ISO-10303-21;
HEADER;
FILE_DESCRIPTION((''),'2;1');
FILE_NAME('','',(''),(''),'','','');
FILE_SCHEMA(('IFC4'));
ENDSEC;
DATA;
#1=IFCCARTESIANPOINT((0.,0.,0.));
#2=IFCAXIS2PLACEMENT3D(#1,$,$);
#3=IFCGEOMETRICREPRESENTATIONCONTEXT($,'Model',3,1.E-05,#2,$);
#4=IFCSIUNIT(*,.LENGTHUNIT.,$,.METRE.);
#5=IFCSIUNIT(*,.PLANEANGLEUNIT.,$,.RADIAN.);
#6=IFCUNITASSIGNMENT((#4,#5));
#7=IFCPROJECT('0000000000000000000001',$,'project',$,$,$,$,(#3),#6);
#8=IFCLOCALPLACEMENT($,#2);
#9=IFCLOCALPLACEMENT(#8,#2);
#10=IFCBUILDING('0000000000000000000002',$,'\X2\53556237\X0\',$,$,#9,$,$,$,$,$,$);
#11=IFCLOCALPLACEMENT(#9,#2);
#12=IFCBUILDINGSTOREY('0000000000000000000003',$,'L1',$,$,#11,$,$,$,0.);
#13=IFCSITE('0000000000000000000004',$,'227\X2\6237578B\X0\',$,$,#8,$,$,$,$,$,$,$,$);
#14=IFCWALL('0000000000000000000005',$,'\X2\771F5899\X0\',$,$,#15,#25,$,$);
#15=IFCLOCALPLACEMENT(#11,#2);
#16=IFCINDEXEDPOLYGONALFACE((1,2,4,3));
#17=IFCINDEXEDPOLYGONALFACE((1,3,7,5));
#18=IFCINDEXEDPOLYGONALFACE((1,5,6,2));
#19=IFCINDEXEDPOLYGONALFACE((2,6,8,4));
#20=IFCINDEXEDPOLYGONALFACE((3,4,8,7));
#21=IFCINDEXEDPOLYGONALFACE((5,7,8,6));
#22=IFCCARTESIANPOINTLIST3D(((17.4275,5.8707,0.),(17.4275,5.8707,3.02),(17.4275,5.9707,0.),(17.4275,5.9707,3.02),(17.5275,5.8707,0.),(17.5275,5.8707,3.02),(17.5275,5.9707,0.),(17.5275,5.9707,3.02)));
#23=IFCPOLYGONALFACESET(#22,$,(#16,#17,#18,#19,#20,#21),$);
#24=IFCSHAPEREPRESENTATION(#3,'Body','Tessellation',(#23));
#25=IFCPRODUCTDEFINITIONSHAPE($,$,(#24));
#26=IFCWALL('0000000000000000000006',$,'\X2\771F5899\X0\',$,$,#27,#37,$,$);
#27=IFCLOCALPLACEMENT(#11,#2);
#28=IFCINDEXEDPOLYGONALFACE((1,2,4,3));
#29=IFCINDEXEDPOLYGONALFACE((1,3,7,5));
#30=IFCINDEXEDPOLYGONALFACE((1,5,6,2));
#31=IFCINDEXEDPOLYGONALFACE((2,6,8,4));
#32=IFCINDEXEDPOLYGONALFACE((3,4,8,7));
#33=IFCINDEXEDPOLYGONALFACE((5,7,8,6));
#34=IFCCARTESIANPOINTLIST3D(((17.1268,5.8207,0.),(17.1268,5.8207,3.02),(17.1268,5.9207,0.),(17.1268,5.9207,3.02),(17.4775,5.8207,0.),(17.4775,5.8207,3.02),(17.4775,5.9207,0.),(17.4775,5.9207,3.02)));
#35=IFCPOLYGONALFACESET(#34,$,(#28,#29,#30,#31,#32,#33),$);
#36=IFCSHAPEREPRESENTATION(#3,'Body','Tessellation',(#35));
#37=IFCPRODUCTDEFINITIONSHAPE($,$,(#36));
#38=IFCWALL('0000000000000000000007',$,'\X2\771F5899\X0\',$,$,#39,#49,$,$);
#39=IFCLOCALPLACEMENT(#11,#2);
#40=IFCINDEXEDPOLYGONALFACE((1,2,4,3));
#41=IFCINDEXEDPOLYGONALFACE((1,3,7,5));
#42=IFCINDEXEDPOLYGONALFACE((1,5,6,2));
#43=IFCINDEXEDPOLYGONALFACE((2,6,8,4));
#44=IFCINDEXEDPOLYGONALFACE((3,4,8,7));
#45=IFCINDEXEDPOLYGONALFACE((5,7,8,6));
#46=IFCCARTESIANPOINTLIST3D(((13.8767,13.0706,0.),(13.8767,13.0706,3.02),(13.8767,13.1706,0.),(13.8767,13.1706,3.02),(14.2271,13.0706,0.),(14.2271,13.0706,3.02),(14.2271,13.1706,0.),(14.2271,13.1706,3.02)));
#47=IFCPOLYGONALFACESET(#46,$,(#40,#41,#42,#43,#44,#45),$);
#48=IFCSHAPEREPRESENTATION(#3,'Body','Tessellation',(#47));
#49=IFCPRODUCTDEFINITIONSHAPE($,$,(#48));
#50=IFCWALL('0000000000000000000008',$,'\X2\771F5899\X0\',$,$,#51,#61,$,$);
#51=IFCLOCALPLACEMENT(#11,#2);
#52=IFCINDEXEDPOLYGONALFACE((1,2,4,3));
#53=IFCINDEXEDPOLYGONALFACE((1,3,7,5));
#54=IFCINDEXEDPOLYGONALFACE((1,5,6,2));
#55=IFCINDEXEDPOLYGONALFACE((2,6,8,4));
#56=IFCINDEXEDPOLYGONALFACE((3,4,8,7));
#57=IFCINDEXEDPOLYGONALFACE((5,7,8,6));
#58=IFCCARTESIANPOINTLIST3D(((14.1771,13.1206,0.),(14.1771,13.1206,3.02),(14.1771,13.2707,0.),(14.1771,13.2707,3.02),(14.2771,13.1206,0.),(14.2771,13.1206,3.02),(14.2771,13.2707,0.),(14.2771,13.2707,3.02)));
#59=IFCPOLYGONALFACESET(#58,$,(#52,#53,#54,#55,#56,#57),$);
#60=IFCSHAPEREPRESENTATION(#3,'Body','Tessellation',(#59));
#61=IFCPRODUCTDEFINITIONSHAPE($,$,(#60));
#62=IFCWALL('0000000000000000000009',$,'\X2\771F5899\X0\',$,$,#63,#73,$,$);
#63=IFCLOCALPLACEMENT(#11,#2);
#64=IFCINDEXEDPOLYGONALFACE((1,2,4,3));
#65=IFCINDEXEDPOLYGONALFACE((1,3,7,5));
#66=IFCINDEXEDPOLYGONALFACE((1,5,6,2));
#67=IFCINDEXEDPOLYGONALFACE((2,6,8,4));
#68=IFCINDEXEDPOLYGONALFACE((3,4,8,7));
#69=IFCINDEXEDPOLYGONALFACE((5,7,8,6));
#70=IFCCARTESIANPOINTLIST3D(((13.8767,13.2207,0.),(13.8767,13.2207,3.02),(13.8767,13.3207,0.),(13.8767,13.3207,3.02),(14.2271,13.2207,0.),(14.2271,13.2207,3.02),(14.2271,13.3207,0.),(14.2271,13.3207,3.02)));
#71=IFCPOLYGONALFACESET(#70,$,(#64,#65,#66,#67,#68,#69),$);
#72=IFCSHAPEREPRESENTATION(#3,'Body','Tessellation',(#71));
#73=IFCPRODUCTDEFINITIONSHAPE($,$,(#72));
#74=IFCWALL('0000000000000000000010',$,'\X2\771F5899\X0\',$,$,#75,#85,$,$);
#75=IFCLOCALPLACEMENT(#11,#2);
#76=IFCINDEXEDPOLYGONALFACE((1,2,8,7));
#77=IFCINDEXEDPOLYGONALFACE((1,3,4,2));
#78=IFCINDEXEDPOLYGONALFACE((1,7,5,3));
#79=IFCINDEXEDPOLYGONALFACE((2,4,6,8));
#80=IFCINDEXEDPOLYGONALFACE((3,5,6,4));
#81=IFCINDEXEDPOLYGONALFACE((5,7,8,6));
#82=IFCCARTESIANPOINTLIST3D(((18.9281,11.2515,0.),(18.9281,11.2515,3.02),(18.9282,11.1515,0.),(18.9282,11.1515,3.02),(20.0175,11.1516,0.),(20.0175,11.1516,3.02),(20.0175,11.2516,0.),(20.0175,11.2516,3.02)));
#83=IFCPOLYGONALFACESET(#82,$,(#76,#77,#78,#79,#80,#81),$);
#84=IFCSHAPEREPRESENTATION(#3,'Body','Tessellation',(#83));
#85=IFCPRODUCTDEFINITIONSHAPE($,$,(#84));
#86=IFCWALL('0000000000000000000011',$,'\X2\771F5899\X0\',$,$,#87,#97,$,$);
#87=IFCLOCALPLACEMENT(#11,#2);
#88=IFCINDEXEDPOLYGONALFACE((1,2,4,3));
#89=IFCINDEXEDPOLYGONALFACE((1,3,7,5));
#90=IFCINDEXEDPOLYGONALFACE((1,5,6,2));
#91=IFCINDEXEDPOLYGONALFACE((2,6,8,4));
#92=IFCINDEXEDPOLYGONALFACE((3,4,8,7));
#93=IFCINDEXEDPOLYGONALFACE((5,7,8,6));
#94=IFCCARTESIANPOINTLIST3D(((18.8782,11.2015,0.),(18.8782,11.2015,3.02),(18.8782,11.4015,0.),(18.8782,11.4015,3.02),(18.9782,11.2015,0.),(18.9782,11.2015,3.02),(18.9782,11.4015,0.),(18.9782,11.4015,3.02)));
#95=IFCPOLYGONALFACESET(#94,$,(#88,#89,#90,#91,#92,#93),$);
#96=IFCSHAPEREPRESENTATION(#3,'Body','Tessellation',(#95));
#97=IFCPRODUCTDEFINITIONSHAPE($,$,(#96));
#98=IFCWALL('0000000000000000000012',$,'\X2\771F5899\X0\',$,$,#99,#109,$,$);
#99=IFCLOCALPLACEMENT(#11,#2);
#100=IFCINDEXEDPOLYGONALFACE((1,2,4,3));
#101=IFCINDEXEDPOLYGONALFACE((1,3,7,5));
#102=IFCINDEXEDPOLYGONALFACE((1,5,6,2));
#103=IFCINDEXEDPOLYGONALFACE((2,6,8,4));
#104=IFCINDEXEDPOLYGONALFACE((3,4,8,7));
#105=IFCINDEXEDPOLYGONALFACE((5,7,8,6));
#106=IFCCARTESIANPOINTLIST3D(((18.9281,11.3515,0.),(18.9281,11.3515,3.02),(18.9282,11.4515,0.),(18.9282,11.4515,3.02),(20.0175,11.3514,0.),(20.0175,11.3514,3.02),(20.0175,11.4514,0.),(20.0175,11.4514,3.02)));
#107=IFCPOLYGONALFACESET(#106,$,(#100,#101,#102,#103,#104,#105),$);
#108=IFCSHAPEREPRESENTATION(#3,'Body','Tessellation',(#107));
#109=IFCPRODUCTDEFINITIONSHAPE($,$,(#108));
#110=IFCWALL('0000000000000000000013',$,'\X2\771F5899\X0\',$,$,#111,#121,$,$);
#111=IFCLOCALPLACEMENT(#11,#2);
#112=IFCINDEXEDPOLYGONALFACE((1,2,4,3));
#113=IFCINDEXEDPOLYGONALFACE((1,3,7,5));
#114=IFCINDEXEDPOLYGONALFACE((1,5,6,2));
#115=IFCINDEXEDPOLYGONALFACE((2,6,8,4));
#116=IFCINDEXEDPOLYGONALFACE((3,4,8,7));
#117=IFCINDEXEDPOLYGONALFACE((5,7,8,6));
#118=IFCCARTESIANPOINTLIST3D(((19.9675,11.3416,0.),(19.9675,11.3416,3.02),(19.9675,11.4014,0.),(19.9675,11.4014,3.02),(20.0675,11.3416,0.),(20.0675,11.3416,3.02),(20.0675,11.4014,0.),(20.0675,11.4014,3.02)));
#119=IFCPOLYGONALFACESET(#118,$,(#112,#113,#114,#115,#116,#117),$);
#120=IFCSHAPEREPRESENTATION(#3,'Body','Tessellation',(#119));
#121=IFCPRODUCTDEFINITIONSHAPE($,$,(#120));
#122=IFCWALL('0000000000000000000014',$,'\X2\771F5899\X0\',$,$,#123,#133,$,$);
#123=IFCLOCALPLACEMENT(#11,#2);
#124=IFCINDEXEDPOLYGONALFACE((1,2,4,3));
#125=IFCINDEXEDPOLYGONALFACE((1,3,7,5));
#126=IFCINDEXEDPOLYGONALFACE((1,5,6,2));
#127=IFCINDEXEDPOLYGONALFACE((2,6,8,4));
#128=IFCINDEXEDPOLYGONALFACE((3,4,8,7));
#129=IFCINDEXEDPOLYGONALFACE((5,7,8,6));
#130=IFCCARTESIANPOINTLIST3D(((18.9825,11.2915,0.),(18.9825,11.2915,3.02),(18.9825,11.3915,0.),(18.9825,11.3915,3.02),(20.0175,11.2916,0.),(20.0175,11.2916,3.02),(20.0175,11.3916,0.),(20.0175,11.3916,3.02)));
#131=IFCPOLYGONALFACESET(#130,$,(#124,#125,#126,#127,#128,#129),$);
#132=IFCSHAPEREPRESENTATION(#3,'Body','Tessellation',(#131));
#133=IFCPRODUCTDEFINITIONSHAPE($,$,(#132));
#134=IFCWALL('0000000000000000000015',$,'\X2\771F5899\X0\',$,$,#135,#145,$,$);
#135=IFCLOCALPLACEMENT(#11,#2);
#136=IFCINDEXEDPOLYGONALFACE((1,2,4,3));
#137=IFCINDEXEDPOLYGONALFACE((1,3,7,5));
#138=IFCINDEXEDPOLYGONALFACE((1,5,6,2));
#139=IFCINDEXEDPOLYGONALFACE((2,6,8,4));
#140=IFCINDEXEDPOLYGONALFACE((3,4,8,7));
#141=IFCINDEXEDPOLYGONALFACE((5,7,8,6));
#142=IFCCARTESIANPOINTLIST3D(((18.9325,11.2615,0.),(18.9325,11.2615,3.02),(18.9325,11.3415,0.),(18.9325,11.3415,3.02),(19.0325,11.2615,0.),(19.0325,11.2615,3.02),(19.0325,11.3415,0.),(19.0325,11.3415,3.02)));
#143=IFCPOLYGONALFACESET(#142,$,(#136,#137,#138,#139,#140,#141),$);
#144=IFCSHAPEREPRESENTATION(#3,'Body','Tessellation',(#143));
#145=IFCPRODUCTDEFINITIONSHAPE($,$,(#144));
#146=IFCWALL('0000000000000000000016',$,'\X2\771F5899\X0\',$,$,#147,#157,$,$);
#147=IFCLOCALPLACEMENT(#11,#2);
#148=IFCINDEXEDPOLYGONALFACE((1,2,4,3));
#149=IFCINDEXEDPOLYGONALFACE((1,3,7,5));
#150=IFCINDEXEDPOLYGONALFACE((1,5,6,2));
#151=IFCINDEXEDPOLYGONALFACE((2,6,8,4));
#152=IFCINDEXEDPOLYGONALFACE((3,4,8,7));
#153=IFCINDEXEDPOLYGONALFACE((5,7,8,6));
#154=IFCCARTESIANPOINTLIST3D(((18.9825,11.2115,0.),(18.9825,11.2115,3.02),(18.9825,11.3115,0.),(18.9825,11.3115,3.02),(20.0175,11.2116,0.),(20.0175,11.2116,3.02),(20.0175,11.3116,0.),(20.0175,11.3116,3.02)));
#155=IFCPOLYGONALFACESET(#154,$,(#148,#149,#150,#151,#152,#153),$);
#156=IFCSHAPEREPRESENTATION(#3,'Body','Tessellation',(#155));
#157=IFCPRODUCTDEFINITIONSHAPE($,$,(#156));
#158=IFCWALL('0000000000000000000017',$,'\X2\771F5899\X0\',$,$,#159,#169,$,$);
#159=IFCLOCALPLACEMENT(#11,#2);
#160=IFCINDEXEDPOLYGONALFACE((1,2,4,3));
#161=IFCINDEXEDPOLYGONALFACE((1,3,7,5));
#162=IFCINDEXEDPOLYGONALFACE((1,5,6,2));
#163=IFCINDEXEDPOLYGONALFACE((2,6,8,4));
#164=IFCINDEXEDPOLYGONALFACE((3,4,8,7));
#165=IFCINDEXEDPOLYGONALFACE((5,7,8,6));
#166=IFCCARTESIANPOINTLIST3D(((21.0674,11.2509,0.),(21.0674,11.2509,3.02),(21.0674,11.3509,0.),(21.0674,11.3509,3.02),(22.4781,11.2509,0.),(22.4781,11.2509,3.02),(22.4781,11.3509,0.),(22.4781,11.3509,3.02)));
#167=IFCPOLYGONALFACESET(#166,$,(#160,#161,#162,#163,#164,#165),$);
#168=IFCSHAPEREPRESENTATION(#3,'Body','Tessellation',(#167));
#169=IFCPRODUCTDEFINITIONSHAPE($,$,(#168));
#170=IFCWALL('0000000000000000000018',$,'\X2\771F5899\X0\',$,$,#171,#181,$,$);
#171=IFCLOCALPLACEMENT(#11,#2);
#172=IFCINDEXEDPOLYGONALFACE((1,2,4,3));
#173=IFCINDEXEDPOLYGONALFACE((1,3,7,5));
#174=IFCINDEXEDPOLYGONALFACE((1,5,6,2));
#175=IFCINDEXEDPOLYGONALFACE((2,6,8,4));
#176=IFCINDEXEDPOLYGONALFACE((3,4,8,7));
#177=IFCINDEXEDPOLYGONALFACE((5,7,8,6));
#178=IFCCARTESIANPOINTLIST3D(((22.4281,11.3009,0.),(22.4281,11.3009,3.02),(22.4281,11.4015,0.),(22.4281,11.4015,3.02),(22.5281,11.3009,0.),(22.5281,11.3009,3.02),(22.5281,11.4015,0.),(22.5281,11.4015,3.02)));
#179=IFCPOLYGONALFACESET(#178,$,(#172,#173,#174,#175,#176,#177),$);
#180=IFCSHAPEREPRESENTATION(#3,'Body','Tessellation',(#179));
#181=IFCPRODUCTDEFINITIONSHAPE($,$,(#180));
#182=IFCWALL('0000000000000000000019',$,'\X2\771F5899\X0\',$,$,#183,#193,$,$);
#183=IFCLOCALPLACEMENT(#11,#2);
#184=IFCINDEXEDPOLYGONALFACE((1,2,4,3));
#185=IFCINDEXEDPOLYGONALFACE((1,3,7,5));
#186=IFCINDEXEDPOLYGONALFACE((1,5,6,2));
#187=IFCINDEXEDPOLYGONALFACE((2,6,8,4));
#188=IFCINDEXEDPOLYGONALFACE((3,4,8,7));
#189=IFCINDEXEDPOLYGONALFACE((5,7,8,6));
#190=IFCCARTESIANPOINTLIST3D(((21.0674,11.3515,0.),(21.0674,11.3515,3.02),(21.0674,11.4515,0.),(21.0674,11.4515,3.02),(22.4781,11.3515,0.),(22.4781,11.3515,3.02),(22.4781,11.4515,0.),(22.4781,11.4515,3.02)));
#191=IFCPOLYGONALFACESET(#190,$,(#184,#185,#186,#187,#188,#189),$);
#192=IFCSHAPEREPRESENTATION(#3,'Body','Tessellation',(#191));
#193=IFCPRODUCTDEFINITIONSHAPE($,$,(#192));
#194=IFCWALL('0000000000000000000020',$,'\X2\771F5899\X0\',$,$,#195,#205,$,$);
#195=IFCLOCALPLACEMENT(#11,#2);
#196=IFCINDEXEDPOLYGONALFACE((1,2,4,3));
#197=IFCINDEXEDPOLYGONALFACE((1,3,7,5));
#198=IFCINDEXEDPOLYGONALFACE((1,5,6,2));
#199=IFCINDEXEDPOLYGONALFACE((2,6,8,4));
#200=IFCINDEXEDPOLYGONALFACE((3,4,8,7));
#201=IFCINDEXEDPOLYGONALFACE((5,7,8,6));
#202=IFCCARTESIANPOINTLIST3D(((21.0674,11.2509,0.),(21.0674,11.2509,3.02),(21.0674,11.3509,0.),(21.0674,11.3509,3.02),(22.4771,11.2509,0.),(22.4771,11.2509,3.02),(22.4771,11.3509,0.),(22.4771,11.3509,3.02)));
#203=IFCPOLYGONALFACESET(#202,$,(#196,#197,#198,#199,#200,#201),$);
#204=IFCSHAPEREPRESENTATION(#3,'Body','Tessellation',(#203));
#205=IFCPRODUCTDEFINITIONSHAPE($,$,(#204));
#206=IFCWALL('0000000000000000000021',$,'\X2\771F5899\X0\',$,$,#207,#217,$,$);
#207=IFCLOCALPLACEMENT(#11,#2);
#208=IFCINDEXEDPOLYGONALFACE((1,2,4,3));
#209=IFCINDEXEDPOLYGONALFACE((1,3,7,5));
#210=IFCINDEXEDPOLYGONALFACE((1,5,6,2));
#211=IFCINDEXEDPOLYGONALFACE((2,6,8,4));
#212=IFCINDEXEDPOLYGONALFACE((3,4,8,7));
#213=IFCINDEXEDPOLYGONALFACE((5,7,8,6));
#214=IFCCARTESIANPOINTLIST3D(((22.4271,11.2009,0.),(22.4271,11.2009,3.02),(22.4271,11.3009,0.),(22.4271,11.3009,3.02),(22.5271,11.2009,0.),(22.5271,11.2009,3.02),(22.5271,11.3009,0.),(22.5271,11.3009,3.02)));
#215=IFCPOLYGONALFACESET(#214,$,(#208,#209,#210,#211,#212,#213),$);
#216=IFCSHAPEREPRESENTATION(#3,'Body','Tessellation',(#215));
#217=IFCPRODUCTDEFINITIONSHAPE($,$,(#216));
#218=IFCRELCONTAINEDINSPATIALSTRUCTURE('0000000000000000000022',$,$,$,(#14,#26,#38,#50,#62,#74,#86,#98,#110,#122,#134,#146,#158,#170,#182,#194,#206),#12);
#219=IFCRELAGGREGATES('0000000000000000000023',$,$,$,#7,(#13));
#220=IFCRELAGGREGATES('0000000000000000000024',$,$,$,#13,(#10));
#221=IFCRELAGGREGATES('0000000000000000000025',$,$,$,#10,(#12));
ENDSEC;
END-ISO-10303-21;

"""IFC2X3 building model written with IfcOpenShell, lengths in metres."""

from ifc_helpers import new_model, si_unit, origin, place, context, project, spatial, polyline, outline, extrude, element, save


model = new_model("IFC2X3")

# Units and contexts
model_context = context("Model", 3, precision=1e-05, world=origin())
ifc_project = project(units=[si_unit("LENGTHUNIT", "METRE"), si_unit("PLANEANGLEUNIT", "RADIAN")], contexts=[model_context])

# Site, building, storey
site_placement = place(None, origin())
site = spatial("IfcSite", under=ifc_project, at=site_placement, Name="227户型")
building_placement = place(site_placement, origin())
building = spatial("IfcBuilding", under=site, at=building_placement, Name="单户")
storey_placement = place(building_placement, origin())
storey = spatial("IfcBuildingStorey", under=building, at=storey_placement, Name="L1", Elevation=0.0)

# Walls
wall_1_placement = place(storey_placement, origin())
element("IfcWall", 1, at=wall_1_placement, inside=storey, Name="真墙", context=model_context, shape_type="SweptSolid", body=[
    extrude(outline(polyline([(17.5275, 5.9707), (17.5275, 5.8707), (17.4275, 5.8707), (17.4275, 5.9707), (17.5275, 5.9707)])), origin(), (0.0, 0.0, 1.0), 3.02),
])
wall_2_placement = place(storey_placement, origin())
element("IfcWall", 2, at=wall_2_placement, inside=storey, Name="真墙", context=model_context, shape_type="SweptSolid", body=[
    extrude(outline(polyline([(17.4775, 5.8207), (17.1268, 5.8207), (17.1268, 5.9207), (17.4775, 5.9207), (17.4775, 5.8207)])), origin(), (0.0, 0.0, 1.0), 3.02),
])
wall_3_placement = place(storey_placement, origin())
element("IfcWall", 3, at=wall_3_placement, inside=storey, Name="真墙", context=model_context, shape_type="SweptSolid", body=[
    extrude(outline(polyline([(13.8767, 13.1706), (14.2271, 13.1706), (14.2271, 13.0706), (13.8767, 13.0706), (13.8767, 13.1706)])), origin(), (0.0, 0.0, 1.0), 3.02),
])
wall_4_placement = place(storey_placement, origin())
element("IfcWall", 4, at=wall_4_placement, inside=storey, Name="真墙", context=model_context, shape_type="SweptSolid", body=[
    extrude(outline(polyline([(14.1771, 13.1206), (14.1771, 13.2707), (14.2771, 13.2707), (14.2771, 13.1206), (14.1771, 13.1206)])), origin(), (0.0, 0.0, 1.0), 3.02),
])
wall_5_placement = place(storey_placement, origin())
element("IfcWall", 5, at=wall_5_placement, inside=storey, Name="真墙", context=model_context, shape_type="SweptSolid", body=[
    extrude(outline(polyline([(14.2271, 13.2207), (13.8767, 13.2207), (13.8767, 13.3207), (14.2271, 13.3207), (14.2271, 13.2207)])), origin(), (0.0, 0.0, 1.0), 3.02),
])
wall_6_placement = place(storey_placement, origin())
element("IfcWall", 6, at=wall_6_placement, inside=storey, Name="真墙", context=model_context, shape_type="SweptSolid", body=[
    extrude(outline(polyline([(20.0175, 11.1516), (18.9282, 11.1515), (18.9281, 11.2515), (20.0175, 11.2516), (20.0175, 11.1516)])), origin(), (0.0, 0.0, 1.0), 3.02),
])
wall_7_placement = place(storey_placement, origin())
element("IfcWall", 7, at=wall_7_placement, inside=storey, Name="真墙", context=model_context, shape_type="SweptSolid", body=[
    extrude(outline(polyline([(18.8782, 11.2015), (18.8782, 11.4015), (18.9782, 11.4015), (18.9782, 11.2015), (18.8782, 11.2015)])), origin(), (0.0, 0.0, 1.0), 3.02),
])
wall_8_placement = place(storey_placement, origin())
element("IfcWall", 8, at=wall_8_placement, inside=storey, Name="真墙", context=model_context, shape_type="SweptSolid", body=[
    extrude(outline(polyline([(18.9282, 11.4515), (20.0175, 11.4514), (20.0175, 11.3514), (18.9281, 11.3515), (18.9282, 11.4515)])), origin(), (0.0, 0.0, 1.0), 3.02),
])
wall_9_placement = place(storey_placement, origin())
element("IfcWall", 9, at=wall_9_placement, inside=storey, Name="真墙", context=model_context, shape_type="SweptSolid", body=[
    extrude(outline(polyline([(20.0675, 11.4014), (20.0675, 11.3416), (19.9675, 11.3416), (19.9675, 11.4014), (20.0675, 11.4014)])), origin(), (0.0, 0.0, 1.0), 3.02),
])
wall_10_placement = place(storey_placement, origin())
element("IfcWall", 10, at=wall_10_placement, inside=storey, Name="真墙", context=model_context, shape_type="SweptSolid", body=[
    extrude(outline(polyline([(20.0175, 11.2916), (18.9825, 11.2915), (18.9825, 11.3915), (20.0175, 11.3916), (20.0175, 11.2916)])), origin(), (0.0, 0.0, 1.0), 3.02),
])
wall_11_placement = place(storey_placement, origin())
element("IfcWall", 11, at=wall_11_placement, inside=storey, Name="真墙", context=model_context, shape_type="SweptSolid", body=[
    extrude(outline(polyline([(19.0325, 11.3415), (19.0325, 11.2615), (18.9325, 11.2615), (18.9325, 11.3415), (19.0325, 11.3415)])), origin(), (0.0, 0.0, 1.0), 3.02),
])
wall_12_placement = place(storey_placement, origin())
element("IfcWall", 12, at=wall_12_placement, inside=storey, Name="真墙", context=model_context, shape_type="SweptSolid", body=[
    extrude(outline(polyline([(18.9825, 11.3115), (20.0175, 11.3116), (20.0175, 11.2116), (18.9825, 11.2115), (18.9825, 11.3115)])), origin(), (0.0, 0.0, 1.0), 3.02),
])
wall_13_placement = place(storey_placement, origin())
element("IfcWall", 13, at=wall_13_placement, inside=storey, Name="真墙", context=model_context, shape_type="SweptSolid", body=[
    extrude(outline(polyline([(21.0674, 11.3509), (22.4781, 11.3509), (22.4781, 11.2509), (21.0674, 11.2509), (21.0674, 11.3509)])), origin(), (0.0, 0.0, 1.0), 3.02),
])
wall_14_placement = place(storey_placement, origin())
element("IfcWall", 14, at=wall_14_placement, inside=storey, Name="真墙", context=model_context, shape_type="SweptSolid", body=[
    extrude(outline(polyline([(22.4281, 11.3009), (22.4281, 11.4015), (22.5281, 11.4015), (22.5281, 11.3009), (22.4281, 11.3009)])), origin(), (0.0, 0.0, 1.0), 3.02),
])
wall_15_placement = place(storey_placement, origin())
element("IfcWall", 15, at=wall_15_placement, inside=storey, Name="真墙", context=model_context, shape_type="SweptSolid", body=[
    extrude(outline(polyline([(22.4781, 11.3515), (21.0674, 11.3515), (21.0674, 11.4515), (22.4781, 11.4515), (22.4781, 11.3515)])), origin(), (0.0, 0.0, 1.0), 3.02),
])
wall_16_placement = place(storey_placement, origin())
element("IfcWall", 16, at=wall_16_placement, inside=storey, Name="真墙", context=model_context, shape_type="SweptSolid", body=[
    extrude(outline(polyline([(21.0674, 11.3509), (22.4771, 11.3509), (22.4771, 11.2509), (21.0674, 11.2509), (21.0674, 11.3509)])), origin(), (0.0, 0.0, 1.0), 3.02),
])
wall_17_placement = place(storey_placement, origin())
element("IfcWall", 17, at=wall_17_placement, inside=storey, Name="真墙", context=model_context, shape_type="SweptSolid", body=[
    extrude(outline(polyline([(22.5271, 11.3009), (22.5271, 11.2009), (22.4271, 11.2009), (22.4271, 11.3009), (22.5271, 11.3009)])), origin(), (0.0, 0.0, 1.0), 3.02),
])

save(model, "model.ifc")
